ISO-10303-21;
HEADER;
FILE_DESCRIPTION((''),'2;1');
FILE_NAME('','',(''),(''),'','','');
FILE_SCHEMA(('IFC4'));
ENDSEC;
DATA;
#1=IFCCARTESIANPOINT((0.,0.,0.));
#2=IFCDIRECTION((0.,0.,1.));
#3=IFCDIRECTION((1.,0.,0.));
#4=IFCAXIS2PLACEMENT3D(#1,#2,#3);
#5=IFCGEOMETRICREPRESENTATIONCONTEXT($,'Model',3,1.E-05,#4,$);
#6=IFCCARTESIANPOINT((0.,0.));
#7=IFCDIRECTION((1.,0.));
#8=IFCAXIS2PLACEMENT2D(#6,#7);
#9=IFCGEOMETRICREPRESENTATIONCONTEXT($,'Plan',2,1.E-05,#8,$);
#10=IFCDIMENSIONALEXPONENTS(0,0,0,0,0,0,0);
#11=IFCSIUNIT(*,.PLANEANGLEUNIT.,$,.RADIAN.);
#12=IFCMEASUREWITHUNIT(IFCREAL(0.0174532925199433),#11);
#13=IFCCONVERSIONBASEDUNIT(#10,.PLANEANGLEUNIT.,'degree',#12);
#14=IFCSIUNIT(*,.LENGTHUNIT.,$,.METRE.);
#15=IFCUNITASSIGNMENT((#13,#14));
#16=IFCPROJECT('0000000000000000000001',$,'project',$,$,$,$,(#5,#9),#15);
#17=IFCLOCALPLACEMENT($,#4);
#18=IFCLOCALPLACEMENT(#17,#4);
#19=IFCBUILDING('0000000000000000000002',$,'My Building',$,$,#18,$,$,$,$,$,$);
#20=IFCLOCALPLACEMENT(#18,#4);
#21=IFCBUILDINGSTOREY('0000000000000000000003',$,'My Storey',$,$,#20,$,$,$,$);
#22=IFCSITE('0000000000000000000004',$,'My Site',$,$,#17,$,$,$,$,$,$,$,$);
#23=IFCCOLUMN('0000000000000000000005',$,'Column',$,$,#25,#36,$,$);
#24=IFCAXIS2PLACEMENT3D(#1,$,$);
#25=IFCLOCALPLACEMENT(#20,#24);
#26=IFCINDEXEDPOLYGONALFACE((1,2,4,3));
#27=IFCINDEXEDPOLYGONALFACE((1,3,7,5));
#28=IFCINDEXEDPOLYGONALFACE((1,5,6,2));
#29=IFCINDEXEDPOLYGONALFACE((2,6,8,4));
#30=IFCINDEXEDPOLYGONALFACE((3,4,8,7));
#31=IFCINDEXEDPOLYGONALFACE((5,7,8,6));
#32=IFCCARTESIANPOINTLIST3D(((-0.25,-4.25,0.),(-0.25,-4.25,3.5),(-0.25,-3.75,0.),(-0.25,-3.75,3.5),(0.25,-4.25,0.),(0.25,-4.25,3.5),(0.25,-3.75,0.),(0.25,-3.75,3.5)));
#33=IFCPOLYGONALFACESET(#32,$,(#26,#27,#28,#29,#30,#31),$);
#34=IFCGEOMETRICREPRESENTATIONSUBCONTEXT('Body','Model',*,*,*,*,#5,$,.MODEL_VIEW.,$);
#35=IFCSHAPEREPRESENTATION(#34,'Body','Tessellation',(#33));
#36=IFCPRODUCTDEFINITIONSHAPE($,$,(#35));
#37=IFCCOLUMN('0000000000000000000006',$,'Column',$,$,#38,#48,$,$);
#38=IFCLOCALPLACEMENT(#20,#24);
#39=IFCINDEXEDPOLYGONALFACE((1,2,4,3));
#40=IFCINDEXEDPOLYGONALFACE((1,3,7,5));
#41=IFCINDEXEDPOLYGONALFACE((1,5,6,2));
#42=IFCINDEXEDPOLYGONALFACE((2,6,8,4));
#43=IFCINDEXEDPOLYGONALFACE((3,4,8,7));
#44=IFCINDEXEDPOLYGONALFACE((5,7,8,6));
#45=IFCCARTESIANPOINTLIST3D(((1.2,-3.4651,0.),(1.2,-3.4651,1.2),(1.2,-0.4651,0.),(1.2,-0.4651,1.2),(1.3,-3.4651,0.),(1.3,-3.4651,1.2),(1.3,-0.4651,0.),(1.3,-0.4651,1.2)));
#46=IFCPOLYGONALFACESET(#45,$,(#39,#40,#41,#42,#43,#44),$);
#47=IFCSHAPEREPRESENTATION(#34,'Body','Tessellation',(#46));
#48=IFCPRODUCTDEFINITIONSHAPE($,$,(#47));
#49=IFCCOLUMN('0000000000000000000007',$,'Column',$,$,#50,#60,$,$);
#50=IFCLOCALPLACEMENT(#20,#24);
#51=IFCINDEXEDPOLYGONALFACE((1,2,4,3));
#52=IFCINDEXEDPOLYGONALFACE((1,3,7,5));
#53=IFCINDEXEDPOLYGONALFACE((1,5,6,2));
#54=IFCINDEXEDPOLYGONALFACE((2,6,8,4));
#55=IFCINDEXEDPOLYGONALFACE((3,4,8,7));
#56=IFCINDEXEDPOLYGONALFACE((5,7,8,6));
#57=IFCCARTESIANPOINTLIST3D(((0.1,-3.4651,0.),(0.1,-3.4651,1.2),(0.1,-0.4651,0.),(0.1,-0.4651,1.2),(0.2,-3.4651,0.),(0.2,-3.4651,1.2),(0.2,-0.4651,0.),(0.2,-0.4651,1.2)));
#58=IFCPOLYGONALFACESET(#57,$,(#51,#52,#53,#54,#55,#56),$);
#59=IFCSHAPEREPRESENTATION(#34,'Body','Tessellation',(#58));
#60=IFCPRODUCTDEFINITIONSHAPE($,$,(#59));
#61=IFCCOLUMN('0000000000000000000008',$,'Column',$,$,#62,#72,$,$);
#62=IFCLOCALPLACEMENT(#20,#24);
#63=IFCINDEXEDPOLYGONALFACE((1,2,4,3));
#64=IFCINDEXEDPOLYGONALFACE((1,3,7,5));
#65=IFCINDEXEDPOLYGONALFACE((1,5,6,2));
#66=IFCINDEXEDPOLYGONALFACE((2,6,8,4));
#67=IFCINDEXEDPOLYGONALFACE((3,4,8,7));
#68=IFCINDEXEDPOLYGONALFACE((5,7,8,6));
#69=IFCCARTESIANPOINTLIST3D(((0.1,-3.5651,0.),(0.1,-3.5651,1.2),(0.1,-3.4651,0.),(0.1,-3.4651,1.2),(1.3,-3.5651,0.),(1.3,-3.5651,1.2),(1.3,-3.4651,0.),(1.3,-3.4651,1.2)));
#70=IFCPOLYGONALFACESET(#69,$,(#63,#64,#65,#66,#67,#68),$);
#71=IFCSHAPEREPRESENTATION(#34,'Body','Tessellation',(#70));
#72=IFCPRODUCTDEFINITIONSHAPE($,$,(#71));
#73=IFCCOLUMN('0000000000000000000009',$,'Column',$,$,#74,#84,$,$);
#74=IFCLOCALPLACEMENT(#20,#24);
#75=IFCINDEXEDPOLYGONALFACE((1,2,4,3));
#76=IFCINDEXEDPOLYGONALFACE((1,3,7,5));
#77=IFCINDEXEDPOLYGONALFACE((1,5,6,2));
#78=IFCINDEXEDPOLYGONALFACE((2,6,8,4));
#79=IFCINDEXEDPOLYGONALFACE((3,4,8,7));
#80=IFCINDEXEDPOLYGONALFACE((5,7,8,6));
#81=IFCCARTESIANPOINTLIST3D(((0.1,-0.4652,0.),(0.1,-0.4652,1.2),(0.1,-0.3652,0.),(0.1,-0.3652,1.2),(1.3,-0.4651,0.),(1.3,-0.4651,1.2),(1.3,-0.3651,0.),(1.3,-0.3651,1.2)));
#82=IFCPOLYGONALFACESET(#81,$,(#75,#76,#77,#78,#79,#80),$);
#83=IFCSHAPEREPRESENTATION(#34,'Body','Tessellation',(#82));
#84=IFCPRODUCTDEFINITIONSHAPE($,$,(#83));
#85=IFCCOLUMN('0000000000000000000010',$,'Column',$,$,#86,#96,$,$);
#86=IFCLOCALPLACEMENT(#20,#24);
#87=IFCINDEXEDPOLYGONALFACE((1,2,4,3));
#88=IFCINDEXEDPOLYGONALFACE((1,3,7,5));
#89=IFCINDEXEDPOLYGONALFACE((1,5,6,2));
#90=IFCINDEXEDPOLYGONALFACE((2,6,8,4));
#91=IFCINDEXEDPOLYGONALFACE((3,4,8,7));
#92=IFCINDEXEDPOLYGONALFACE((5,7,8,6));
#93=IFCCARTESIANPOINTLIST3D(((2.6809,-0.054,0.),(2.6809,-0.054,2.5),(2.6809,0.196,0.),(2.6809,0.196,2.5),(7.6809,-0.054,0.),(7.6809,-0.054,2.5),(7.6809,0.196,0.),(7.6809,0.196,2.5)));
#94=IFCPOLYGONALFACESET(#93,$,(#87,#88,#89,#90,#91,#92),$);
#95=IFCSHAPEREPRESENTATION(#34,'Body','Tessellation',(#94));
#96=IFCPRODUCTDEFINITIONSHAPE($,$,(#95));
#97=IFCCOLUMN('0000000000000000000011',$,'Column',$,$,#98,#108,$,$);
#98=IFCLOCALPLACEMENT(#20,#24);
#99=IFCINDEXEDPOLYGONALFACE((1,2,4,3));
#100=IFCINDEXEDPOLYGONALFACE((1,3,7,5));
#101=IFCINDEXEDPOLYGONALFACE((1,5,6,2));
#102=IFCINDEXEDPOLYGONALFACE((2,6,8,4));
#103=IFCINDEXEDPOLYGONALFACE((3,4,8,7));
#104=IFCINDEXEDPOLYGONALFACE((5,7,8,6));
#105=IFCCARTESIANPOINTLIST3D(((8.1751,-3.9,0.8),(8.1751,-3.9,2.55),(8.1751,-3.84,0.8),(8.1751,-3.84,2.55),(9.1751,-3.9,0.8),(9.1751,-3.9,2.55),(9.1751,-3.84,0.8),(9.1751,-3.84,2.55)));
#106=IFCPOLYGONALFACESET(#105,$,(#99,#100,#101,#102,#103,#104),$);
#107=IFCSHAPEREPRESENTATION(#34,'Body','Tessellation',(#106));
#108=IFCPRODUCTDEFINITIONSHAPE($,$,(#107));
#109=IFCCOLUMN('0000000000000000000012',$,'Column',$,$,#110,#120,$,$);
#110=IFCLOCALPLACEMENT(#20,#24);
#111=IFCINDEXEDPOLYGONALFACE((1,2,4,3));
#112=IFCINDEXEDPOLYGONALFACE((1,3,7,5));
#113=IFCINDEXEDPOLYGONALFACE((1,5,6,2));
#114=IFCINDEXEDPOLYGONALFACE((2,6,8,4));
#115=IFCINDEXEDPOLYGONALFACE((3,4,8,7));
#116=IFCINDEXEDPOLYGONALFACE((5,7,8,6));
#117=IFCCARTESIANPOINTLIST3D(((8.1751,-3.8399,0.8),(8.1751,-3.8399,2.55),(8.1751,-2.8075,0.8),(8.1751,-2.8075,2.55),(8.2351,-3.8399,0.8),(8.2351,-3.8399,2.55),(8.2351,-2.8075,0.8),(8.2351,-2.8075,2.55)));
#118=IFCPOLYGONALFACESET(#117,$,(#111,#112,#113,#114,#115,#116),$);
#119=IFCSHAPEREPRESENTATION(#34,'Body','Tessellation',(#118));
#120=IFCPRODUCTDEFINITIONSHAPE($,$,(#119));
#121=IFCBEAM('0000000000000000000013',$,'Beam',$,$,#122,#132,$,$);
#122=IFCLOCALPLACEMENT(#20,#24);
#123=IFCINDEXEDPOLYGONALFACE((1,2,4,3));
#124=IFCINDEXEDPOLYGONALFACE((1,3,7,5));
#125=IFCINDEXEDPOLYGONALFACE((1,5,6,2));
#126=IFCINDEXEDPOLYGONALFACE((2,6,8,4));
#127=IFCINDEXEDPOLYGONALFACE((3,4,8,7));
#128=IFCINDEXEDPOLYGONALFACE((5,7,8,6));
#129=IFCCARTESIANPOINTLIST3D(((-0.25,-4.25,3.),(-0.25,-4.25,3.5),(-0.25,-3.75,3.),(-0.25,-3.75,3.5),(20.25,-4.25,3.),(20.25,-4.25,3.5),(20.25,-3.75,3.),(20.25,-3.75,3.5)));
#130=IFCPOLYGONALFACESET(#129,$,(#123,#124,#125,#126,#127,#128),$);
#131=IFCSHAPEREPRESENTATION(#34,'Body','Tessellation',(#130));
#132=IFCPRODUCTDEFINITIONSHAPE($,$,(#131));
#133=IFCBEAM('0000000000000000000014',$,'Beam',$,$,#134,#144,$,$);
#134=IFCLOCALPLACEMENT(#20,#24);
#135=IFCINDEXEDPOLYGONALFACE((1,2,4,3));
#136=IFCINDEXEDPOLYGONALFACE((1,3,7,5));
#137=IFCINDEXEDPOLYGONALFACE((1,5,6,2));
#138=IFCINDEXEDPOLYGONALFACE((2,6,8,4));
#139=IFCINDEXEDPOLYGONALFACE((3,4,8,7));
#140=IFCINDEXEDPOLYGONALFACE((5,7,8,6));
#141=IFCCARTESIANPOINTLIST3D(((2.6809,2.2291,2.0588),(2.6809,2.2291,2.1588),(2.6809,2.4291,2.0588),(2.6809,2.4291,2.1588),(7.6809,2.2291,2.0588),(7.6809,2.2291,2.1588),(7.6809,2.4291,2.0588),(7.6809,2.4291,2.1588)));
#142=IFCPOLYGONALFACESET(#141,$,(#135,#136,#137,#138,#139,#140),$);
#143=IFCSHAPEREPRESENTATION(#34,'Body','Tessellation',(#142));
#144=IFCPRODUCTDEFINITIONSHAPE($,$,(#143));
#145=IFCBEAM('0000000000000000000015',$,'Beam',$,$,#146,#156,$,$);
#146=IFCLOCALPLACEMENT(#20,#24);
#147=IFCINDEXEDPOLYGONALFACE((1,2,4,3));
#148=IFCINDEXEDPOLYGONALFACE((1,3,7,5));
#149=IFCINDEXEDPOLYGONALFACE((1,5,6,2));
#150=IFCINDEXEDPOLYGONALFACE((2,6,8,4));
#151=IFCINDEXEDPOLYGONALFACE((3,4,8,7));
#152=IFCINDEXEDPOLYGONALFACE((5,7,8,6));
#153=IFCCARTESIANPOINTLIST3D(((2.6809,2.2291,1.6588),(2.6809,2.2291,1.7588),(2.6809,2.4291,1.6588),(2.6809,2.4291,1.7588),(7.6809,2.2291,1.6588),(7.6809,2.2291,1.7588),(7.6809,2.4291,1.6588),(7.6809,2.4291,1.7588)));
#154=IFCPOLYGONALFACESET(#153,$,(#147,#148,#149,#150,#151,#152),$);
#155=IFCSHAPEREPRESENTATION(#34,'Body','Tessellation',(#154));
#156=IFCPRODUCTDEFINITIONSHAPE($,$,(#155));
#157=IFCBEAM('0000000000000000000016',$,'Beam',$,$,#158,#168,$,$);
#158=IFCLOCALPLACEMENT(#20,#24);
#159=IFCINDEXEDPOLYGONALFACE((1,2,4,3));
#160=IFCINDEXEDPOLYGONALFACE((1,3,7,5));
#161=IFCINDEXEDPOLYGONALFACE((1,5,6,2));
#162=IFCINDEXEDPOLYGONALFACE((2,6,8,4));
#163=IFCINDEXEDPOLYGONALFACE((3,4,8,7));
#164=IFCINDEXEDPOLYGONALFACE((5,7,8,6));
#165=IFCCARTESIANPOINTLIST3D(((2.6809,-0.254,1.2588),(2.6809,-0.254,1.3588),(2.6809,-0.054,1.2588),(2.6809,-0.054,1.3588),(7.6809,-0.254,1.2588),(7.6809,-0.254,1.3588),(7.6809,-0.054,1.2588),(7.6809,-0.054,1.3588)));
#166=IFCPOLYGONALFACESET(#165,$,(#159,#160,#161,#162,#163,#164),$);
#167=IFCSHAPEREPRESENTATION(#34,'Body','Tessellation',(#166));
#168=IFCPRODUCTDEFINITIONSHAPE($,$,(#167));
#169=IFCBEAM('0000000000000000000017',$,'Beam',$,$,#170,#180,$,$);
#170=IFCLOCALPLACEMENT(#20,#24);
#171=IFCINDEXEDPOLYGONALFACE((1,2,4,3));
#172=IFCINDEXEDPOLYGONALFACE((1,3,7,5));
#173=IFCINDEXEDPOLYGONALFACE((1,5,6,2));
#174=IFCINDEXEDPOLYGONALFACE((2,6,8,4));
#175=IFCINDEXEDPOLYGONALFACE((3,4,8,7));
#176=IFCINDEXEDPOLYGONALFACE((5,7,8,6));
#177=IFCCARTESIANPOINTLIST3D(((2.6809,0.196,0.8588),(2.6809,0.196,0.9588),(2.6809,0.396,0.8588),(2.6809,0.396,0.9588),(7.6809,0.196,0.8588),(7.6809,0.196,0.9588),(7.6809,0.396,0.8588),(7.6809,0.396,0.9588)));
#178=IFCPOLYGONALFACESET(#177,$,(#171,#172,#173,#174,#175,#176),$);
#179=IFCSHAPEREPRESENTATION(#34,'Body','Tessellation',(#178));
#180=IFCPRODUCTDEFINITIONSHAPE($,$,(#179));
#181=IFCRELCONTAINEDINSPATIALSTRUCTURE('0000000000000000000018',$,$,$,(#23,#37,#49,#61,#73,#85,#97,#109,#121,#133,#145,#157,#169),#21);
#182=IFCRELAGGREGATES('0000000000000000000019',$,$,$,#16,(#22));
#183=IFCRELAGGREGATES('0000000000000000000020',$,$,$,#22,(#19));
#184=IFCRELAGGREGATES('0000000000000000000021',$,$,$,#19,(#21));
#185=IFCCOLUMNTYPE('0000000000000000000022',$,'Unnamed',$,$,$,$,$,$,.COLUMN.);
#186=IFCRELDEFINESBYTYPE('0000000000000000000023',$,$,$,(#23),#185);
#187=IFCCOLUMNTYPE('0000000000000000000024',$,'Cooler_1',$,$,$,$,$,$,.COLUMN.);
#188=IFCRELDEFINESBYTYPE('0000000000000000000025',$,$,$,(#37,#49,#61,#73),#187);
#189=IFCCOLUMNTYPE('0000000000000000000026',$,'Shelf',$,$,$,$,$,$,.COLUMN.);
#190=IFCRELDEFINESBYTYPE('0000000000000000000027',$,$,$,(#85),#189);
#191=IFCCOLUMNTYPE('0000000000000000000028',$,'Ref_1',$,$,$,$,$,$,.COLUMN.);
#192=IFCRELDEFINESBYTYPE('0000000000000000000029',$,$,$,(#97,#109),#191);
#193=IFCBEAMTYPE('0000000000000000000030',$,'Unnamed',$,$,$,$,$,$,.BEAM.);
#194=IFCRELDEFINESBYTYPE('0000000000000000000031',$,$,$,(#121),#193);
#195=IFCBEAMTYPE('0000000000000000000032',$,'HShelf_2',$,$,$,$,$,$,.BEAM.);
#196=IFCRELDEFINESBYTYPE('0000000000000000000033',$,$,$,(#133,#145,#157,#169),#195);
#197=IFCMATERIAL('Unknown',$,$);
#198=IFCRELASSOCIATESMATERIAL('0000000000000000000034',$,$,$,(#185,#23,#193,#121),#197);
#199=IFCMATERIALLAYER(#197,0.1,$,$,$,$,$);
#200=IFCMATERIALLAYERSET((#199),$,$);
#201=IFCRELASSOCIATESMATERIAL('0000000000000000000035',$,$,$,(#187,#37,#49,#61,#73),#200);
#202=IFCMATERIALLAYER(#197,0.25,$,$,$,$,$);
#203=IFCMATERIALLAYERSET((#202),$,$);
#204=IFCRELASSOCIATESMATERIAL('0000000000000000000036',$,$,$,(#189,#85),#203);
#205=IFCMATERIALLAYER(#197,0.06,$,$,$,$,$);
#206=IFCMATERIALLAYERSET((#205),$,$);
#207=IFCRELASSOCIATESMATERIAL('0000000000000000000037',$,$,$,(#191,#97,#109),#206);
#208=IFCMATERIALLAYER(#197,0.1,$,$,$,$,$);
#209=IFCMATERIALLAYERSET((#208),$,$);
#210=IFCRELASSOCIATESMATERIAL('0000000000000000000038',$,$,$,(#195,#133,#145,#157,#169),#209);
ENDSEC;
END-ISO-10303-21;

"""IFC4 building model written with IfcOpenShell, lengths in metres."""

from ifc_helpers import new_model, entity, si_unit, converted_unit, frame, origin_with_axes, origin_2d_with_axis, place, context, subcontext, project, spatial, line, indexed_curve, rectangle, outline, extrude, material, layer, layer_set, layer_usage, material_profile, profile_set, profile_usage, type_object, element, save


model = new_model("IFC4")

# Units and contexts
model_context = context("Model", 3, precision=1e-05, world=origin_with_axes())
plan_context = context("Plan", 2, precision=1e-05, world=origin_2d_with_axis())
body_context_1 = subcontext(model_context, "Body", "Model", "MODEL_VIEW")
ifc_project = project(units=[converted_unit("PLANEANGLEUNIT", "degree", entity("IfcReal", 0.0174532925199433), si_unit("PLANEANGLEUNIT", "RADIAN"), dimensions=[0, 0, 0, 0, 0, 0, 0]), si_unit("LENGTHUNIT", "METRE")], contexts=[model_context, plan_context])

# Site, building, storey
site_placement = place(None, origin_with_axes())
site = spatial("IfcSite", under=ifc_project, at=site_placement, Name="My Site")
building_placement = place(site_placement, origin_with_axes())
building = spatial("IfcBuilding", under=site, at=building_placement, Name="My Building")
storey_placement = place(building_placement, origin_with_axes())
storey = spatial("IfcBuildingStorey", under=building, at=storey_placement, Name="My Storey")

# Columns
ifc_material = material(Name="Unknown")
ifc_material_profile_1 = material_profile(ifc_material, rectangle(XDim=0.5, YDim=0.5))
ifc_profile_set_1 = profile_set([ifc_material_profile_1])
ifc_profile_usage_1 = profile_usage(ifc_profile_set_1, cardinal=5)
column_type_1 = type_object("IfcColumnType", Name="Unnamed", PredefinedType="COLUMN", material=ifc_profile_set_1)
column_1_placement = place(storey_placement, frame((0.0, -4.0, 0.0), z_axis=(0.0, 0.0, 1.0), x_axis=(1.0, 0.0, 0.0)))
element("IfcColumn", 1, at=column_1_placement, inside=storey, type_object=column_type_1, material=ifc_profile_usage_1, Name="Column", context=body_context_1, shape_type="SweptSolid", body=[
    extrude(rectangle(XDim=0.5, YDim=0.5), origin_with_axes(), (0.0, 0.0, 1.0), 3.5),
])
ifc_layer_1 = layer(ifc_material, 0.1)
ifc_layer_set_1 = layer_set([ifc_layer_1])
ifc_layer_usage_1 = layer_usage(ifc_layer_set_1, "AXIS2", "POSITIVE", 0.0)
column_type_2 = type_object("IfcColumnType", Name="Cooler_1", PredefinedType="COLUMN", material=ifc_layer_set_1)
column_2_placement = place(storey_placement, frame((1.2, -0.4651, 0.0), z_axis=(0.0, 0.0, 1.0), x_axis=(0.000015, -1.0, 0.0)))
element("IfcColumn", 2, at=column_2_placement, inside=storey, type_object=column_type_2, material=ifc_layer_usage_1, Name="Column", context=body_context_1, shape_type="SweptSolid", body=[
    extrude(outline(indexed_curve([(0.0, 0.0), (0.0, 0.1), (3.0, 0.1), (3.0, 0.0)], segments=[line(1, 2, 3, 4, 1)])), origin_with_axes(), (0.0, 0.0, 1.0), 1.2),
])
ifc_layer_usage_2 = layer_usage(ifc_layer_set_1, "AXIS2", "POSITIVE", 0.0)
column_3_placement = place(storey_placement, frame((0.2, -3.4651, 0.0), z_axis=(0.0, 0.0, 1.0), x_axis=(-0.000015, 1.0, 0.0)))
element("IfcColumn", 3, at=column_3_placement, inside=storey, type_object=column_type_2, material=ifc_layer_usage_2, Name="Column", context=body_context_1, shape_type="SweptSolid", body=[
    extrude(outline(indexed_curve([(0.0, 0.0), (0.0, 0.1), (3.0, 0.1), (3.0, 0.0)], segments=[line(1, 2, 3, 4, 1)])), origin_with_axes(), (0.0, 0.0, 1.0), 1.2),
])
ifc_layer_usage_3 = layer_usage(ifc_layer_set_1, "AXIS2", "POSITIVE", 0.0)
column_4_placement = place(storey_placement, frame((0.1, -3.5651, 0.0), z_axis=(0.0, 0.0, 1.0), x_axis=(1.0, 0.000015, 0.0)))
element("IfcColumn", 4, at=column_4_placement, inside=storey, type_object=column_type_2, material=ifc_layer_usage_3, Name="Column", context=body_context_1, shape_type="SweptSolid", body=[
    extrude(outline(indexed_curve([(0.0, 0.0), (0.0, 0.1), (1.2, 0.1), (1.2, 0.0)], segments=[line(1, 2, 3, 4, 1)])), origin_with_axes(), (0.0, 0.0, 1.0), 1.2),
])
ifc_layer_usage_4 = layer_usage(ifc_layer_set_1, "AXIS2", "POSITIVE", 0.0)
column_5_placement = place(storey_placement, frame((0.1, -0.4652, 0.0), z_axis=(0.0, 0.0, 1.0), x_axis=(1.0, 0.000015, 0.0)))
element("IfcColumn", 5, at=column_5_placement, inside=storey, type_object=column_type_2, material=ifc_layer_usage_4, Name="Column", context=body_context_1, shape_type="SweptSolid", body=[
    extrude(outline(indexed_curve([(0.0, 0.0), (0.0, 0.1), (1.2, 0.1), (1.2, 0.0)], segments=[line(1, 2, 3, 4, 1)])), origin_with_axes(), (0.0, 0.0, 1.0), 1.2),
])
ifc_layer_2 = layer(ifc_material, 0.25)
ifc_layer_set_2 = layer_set([ifc_layer_2])
ifc_layer_usage_5 = layer_usage(ifc_layer_set_2, "AXIS2", "POSITIVE", 0.0)
column_type_3 = type_object("IfcColumnType", Name="Shelf", PredefinedType="COLUMN", material=ifc_layer_set_2)
column_6_placement = place(storey_placement, frame((7.6809, 0.196, 0.0), z_axis=(0.0, 0.0, 1.0), x_axis=(-1.0, 0.0, 0.0)))
element("IfcColumn", 6, at=column_6_placement, inside=storey, type_object=column_type_3, material=ifc_layer_usage_5, Name="Column", context=body_context_1, shape_type="SweptSolid", body=[
    extrude(outline(indexed_curve([(0.0, 0.0), (0.0, 0.25), (5.0, 0.25), (5.0, 0.0)], segments=[line(1, 2, 3, 4, 1)])), origin_with_axes(), (0.0, 0.0, 1.0), 2.5),
])
ifc_layer_3 = layer(ifc_material, 0.06)
ifc_layer_set_3 = layer_set([ifc_layer_3])
ifc_layer_usage_6 = layer_usage(ifc_layer_set_3, "AXIS2", "POSITIVE", 0.0)
column_type_4 = type_object("IfcColumnType", Name="Ref_1", PredefinedType="COLUMN", material=ifc_layer_set_3)
column_7_placement = place(storey_placement, frame((8.1751, -3.9, 0.8), z_axis=(0.0, 0.0, 1.0), x_axis=(1.0, 0.0, 0.0)))
element("IfcColumn", 7, at=column_7_placement, inside=storey, type_object=column_type_4, material=ifc_layer_usage_6, Name="Column", context=body_context_1, shape_type="SweptSolid", body=[
    extrude(outline(indexed_curve([(0.0, 0.0), (0.0, 0.06), (1.0, 0.06), (1.0, 0.0)], segments=[line(1, 2, 3, 4, 1)])), origin_with_axes(), (0.0, 0.0, 1.0), 1.75),
])
ifc_layer_usage_7 = layer_usage(ifc_layer_set_3, "AXIS2", "POSITIVE", 0.0)
column_8_placement = place(storey_placement, frame((8.1751, -2.8075, 0.8), z_axis=(0.0, 0.0, 1.0), x_axis=(0.000001, -1.0, 0.0)))
element("IfcColumn", 8, at=column_8_placement, inside=storey, type_object=column_type_4, material=ifc_layer_usage_7, Name="Column", context=body_context_1, shape_type="SweptSolid", body=[
    extrude(outline(indexed_curve([(0.0, 0.0), (0.0, 0.06), (1.0325, 0.06), (1.0325, 0.0)], segments=[line(1, 2, 3, 4, 1)])), origin_with_axes(), (0.0, 0.0, 1.0), 1.75),
])

# Beams
ifc_material_profile_2 = material_profile(ifc_material, rectangle(XDim=0.5, YDim=0.5))
ifc_profile_set_2 = profile_set([ifc_material_profile_2])
ifc_profile_usage_2 = profile_usage(ifc_profile_set_2, cardinal=5)
beam_type_1 = type_object("IfcBeamType", Name="Unnamed", PredefinedType="BEAM", material=ifc_profile_set_2)
beam_1_placement = place(storey_placement, frame((-0.25, -4.0, 3.25), z_axis=(1.0, -0.000001, 0.000001), x_axis=(0.000001, 1.0, 0.0)))
element("IfcBeam", 9, at=beam_1_placement, inside=storey, type_object=beam_type_1, material=ifc_profile_usage_2, Name="Beam", context=body_context_1, shape_type="SweptSolid", body=[
    extrude(rectangle(XDim=0.5, YDim=0.5), origin_with_axes(), (0.0, 0.0, 1.0), 20.5),
])
ifc_layer_4 = layer(ifc_material, 0.1)
ifc_layer_set_4 = layer_set([ifc_layer_4])
ifc_layer_usage_8 = layer_usage(ifc_layer_set_4, "AXIS3", "POSITIVE", -0.1)
beam_type_2 = type_object("IfcBeamType", Name="HShelf_2", PredefinedType="BEAM", material=ifc_layer_set_4)
beam_2_placement = place(storey_placement, frame((2.6809, 2.4291, 2.1588), z_axis=(0.0, 0.0, 1.0), x_axis=(1.0, 0.0, 0.0)))
element("IfcBeam", 10, at=beam_2_placement, inside=storey, type_object=beam_type_2, material=ifc_layer_usage_8, Name="Beam", context=body_context_1, shape_type="SweptSolid", body=[
    extrude(outline(indexed_curve([(0.0, 0.0), (0.0, -0.2), (5.0, -0.2), (5.0, 0.0), (0.0, 0.0)])), frame((0.0, 0.0, -0.1), z_axis=(0.0, 0.0, 1.0), x_axis=(1.0, 0.0, 0.0)), (0.0, 0.0, 1.0), 0.1),
])
ifc_layer_usage_9 = layer_usage(ifc_layer_set_4, "AXIS3", "POSITIVE", -0.1)
beam_3_placement = place(storey_placement, frame((2.6809, 2.4291, 1.7588), z_axis=(0.0, 0.0, 1.0), x_axis=(1.0, 0.0, 0.0)))
element("IfcBeam", 11, at=beam_3_placement, inside=storey, type_object=beam_type_2, material=ifc_layer_usage_9, Name="Beam", context=body_context_1, shape_type="SweptSolid", body=[
    extrude(outline(indexed_curve([(0.0, 0.0), (0.0, -0.2), (5.0, -0.2), (5.0, 0.0), (0.0, 0.0)])), frame((0.0, 0.0, -0.1), z_axis=(0.0, 0.0, 1.0), x_axis=(1.0, 0.0, 0.0)), (0.0, 0.0, 1.0), 0.1),
])
ifc_layer_usage_10 = layer_usage(ifc_layer_set_4, "AXIS3", "POSITIVE", -0.1)
beam_4_placement = place(storey_placement, frame((2.6809, -0.054, 1.3588), z_axis=(0.0, 0.0, 1.0), x_axis=(1.0, 0.0, 0.0)))
element("IfcBeam", 12, at=beam_4_placement, inside=storey, type_object=beam_type_2, material=ifc_layer_usage_10, Name="Beam", context=body_context_1, shape_type="SweptSolid", body=[
    extrude(outline(indexed_curve([(0.0, 0.0), (0.0, -0.2), (5.0, -0.2), (5.0, 0.0), (0.0, 0.0)])), frame((0.0, 0.0, -0.1), z_axis=(0.0, 0.0, 1.0), x_axis=(1.0, 0.0, 0.0)), (0.0, 0.0, 1.0), 0.1),
])
ifc_layer_usage_11 = layer_usage(ifc_layer_set_4, "AXIS3", "POSITIVE", -0.1)
beam_5_placement = place(storey_placement, frame((2.6809, 0.396, 0.9588), z_axis=(0.0, 0.0, 1.0), x_axis=(1.0, 0.0, 0.0)))
element("IfcBeam", 13, at=beam_5_placement, inside=storey, type_object=beam_type_2, material=ifc_layer_usage_11, Name="Beam", context=body_context_1, shape_type="SweptSolid", body=[
    extrude(outline(indexed_curve([(0.0, 0.0), (0.0, -0.2), (5.0, -0.2), (5.0, 0.0), (0.0, 0.0)])), frame((0.0, 0.0, -0.1), z_axis=(0.0, 0.0, 1.0), x_axis=(1.0, 0.0, 0.0)), (0.0, 0.0, 1.0), 0.1),
])

save(model, "model.ifc")
